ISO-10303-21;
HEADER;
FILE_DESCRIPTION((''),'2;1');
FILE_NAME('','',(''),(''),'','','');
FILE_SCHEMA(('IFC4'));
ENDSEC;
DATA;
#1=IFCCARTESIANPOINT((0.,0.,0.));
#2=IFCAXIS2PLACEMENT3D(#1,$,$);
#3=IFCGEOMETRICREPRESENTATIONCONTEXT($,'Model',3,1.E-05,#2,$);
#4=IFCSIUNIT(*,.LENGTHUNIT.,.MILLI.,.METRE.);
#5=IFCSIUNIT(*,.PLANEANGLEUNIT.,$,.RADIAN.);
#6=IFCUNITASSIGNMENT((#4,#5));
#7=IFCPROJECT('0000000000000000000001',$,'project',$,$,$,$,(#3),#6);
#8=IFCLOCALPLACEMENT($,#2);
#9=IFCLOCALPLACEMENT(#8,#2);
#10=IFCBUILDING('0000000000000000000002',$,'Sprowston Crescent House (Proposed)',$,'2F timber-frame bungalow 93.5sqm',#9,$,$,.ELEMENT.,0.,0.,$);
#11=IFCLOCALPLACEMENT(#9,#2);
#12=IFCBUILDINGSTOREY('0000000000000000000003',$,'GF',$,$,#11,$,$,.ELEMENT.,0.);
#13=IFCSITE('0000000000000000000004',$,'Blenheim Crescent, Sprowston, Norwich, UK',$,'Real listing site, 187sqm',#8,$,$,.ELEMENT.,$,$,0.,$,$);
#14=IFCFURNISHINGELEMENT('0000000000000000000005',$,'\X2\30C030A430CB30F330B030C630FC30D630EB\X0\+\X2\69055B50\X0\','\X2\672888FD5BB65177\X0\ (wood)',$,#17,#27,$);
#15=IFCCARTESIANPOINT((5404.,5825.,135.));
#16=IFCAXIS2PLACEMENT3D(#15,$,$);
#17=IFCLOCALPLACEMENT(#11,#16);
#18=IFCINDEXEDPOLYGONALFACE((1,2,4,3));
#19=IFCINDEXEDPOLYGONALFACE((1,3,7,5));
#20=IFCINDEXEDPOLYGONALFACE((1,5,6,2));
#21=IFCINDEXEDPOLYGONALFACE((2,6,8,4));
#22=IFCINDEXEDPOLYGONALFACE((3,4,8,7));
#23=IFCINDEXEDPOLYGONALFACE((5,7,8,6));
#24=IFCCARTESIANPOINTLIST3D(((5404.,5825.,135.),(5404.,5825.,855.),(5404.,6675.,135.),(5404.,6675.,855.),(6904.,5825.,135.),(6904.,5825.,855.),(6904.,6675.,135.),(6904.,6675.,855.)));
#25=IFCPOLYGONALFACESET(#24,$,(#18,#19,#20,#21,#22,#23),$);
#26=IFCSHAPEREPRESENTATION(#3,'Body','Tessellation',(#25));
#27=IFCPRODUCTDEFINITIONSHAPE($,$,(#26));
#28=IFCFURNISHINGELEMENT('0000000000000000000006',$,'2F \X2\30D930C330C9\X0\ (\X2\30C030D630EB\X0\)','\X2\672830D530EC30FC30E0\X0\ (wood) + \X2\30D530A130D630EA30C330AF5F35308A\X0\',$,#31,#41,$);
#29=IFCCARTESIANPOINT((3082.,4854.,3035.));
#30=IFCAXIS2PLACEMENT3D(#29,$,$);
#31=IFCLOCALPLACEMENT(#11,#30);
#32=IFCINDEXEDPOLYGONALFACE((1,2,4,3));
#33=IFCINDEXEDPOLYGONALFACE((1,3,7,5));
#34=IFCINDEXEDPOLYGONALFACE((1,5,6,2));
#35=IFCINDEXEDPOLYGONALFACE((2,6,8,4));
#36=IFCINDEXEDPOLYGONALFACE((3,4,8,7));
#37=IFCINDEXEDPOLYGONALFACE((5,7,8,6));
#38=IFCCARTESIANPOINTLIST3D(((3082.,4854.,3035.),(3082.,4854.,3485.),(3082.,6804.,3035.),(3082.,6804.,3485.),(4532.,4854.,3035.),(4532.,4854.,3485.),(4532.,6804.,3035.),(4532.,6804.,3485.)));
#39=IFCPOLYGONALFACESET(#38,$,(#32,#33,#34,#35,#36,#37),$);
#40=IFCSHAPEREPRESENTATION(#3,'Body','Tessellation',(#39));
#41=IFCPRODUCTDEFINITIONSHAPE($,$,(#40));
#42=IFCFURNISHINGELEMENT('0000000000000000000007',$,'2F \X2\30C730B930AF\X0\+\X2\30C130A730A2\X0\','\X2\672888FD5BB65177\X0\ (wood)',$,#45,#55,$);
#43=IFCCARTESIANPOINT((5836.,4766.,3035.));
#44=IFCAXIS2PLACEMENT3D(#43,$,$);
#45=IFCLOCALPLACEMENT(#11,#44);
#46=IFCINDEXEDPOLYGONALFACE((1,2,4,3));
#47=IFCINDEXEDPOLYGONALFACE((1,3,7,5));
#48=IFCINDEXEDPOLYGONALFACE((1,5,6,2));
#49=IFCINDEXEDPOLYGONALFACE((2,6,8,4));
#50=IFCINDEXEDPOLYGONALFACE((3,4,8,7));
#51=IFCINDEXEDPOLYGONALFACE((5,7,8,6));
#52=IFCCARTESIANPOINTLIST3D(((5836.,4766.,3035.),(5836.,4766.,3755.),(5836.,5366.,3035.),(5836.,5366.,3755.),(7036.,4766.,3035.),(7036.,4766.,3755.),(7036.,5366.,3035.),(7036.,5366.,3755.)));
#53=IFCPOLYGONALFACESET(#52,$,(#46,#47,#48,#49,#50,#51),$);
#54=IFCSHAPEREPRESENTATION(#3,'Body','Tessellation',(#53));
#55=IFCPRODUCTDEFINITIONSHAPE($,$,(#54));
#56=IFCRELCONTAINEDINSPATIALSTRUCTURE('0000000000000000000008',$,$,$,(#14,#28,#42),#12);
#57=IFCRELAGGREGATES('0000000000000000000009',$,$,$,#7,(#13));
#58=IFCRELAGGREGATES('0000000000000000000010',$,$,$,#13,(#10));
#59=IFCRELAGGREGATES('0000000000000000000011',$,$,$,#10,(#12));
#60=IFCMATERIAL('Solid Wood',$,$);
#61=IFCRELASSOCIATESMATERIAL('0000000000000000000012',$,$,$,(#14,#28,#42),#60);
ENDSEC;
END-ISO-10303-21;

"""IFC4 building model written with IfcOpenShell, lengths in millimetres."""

from ifc_helpers import new_model, si_unit, frame, frame_2d, origin, place, context, project, spatial, rectangle, extrude, material, element, save


model = new_model("IFC4")

# Units and contexts
model_context = context("Model", 3, precision=1e-05, world=origin())
ifc_project = project(units=[si_unit("LENGTHUNIT", "METRE", prefix="MILLI"), si_unit("PLANEANGLEUNIT", "RADIAN")], contexts=[model_context])

# Site, building, storey
site_placement = place(None, origin())
site = spatial("IfcSite", under=ifc_project, at=site_placement, Name="Blenheim Crescent, Sprowston, Norwich, UK", ObjectType="Real listing site, 187sqm", CompositionType="ELEMENT", RefElevation=0.0)
building_placement = place(site_placement, origin())
building = spatial("IfcBuilding", under=site, at=building_placement, Name="Sprowston Crescent House (Proposed)", ObjectType="2F timber-frame bungalow 93.5sqm", CompositionType="ELEMENT", ElevationOfRefHeight=0.0, ElevationOfTerrain=0.0)
storey_placement = place(building_placement, origin())
storey = spatial("IfcBuildingStorey", under=building, at=storey_placement, Name="GF", CompositionType="ELEMENT", Elevation=0.0)

# Shared definitions
ifc_material_1 = material(Name="Solid Wood")

# Furnishing elements
furnishing_1_placement = place(storey_placement, frame((5404.0, 5825.0, 135.0)))
element("IfcFurnishingElement", 1, at=furnishing_1_placement, inside=storey, material=ifc_material_1, Name="ダイニングテーブル+椅子", Description="木製家具 (wood)", context=model_context, shape_type="SweptSolid", body=[
    extrude(rectangle(XDim=1500.0, YDim=850.0, at=frame_2d((750.0, 425.0))), frame((5404.0, 5825.0, 135.0)), (0.0, 0.0, 1.0), 720.0),
])
furnishing_2_placement = place(storey_placement, frame((3082.0, 4854.0, 3035.0)))
element("IfcFurnishingElement", 2, at=furnishing_2_placement, inside=storey, material=ifc_material_1, Name="2F ベッド (ダブル)", Description="木フレーム (wood) + ファブリック張り", context=model_context, shape_type="SweptSolid", body=[
    extrude(rectangle(XDim=1450.0, YDim=1950.0, at=frame_2d((725.0, 975.0))), frame((3082.0, 4854.0, 3035.0)), (0.0, 0.0, 1.0), 450.0),
])
furnishing_3_placement = place(storey_placement, frame((5836.0, 4766.0, 3035.0)))
element("IfcFurnishingElement", 3, at=furnishing_3_placement, inside=storey, material=ifc_material_1, Name="2F デスク+チェア", Description="木製家具 (wood)", context=model_context, shape_type="SweptSolid", body=[
    extrude(rectangle(XDim=1200.0, YDim=600.0, at=frame_2d((600.0, 300.0))), frame((5836.0, 4766.0, 3035.0)), (0.0, 0.0, 1.0), 720.0),
])

save(model, "model.ifc")
